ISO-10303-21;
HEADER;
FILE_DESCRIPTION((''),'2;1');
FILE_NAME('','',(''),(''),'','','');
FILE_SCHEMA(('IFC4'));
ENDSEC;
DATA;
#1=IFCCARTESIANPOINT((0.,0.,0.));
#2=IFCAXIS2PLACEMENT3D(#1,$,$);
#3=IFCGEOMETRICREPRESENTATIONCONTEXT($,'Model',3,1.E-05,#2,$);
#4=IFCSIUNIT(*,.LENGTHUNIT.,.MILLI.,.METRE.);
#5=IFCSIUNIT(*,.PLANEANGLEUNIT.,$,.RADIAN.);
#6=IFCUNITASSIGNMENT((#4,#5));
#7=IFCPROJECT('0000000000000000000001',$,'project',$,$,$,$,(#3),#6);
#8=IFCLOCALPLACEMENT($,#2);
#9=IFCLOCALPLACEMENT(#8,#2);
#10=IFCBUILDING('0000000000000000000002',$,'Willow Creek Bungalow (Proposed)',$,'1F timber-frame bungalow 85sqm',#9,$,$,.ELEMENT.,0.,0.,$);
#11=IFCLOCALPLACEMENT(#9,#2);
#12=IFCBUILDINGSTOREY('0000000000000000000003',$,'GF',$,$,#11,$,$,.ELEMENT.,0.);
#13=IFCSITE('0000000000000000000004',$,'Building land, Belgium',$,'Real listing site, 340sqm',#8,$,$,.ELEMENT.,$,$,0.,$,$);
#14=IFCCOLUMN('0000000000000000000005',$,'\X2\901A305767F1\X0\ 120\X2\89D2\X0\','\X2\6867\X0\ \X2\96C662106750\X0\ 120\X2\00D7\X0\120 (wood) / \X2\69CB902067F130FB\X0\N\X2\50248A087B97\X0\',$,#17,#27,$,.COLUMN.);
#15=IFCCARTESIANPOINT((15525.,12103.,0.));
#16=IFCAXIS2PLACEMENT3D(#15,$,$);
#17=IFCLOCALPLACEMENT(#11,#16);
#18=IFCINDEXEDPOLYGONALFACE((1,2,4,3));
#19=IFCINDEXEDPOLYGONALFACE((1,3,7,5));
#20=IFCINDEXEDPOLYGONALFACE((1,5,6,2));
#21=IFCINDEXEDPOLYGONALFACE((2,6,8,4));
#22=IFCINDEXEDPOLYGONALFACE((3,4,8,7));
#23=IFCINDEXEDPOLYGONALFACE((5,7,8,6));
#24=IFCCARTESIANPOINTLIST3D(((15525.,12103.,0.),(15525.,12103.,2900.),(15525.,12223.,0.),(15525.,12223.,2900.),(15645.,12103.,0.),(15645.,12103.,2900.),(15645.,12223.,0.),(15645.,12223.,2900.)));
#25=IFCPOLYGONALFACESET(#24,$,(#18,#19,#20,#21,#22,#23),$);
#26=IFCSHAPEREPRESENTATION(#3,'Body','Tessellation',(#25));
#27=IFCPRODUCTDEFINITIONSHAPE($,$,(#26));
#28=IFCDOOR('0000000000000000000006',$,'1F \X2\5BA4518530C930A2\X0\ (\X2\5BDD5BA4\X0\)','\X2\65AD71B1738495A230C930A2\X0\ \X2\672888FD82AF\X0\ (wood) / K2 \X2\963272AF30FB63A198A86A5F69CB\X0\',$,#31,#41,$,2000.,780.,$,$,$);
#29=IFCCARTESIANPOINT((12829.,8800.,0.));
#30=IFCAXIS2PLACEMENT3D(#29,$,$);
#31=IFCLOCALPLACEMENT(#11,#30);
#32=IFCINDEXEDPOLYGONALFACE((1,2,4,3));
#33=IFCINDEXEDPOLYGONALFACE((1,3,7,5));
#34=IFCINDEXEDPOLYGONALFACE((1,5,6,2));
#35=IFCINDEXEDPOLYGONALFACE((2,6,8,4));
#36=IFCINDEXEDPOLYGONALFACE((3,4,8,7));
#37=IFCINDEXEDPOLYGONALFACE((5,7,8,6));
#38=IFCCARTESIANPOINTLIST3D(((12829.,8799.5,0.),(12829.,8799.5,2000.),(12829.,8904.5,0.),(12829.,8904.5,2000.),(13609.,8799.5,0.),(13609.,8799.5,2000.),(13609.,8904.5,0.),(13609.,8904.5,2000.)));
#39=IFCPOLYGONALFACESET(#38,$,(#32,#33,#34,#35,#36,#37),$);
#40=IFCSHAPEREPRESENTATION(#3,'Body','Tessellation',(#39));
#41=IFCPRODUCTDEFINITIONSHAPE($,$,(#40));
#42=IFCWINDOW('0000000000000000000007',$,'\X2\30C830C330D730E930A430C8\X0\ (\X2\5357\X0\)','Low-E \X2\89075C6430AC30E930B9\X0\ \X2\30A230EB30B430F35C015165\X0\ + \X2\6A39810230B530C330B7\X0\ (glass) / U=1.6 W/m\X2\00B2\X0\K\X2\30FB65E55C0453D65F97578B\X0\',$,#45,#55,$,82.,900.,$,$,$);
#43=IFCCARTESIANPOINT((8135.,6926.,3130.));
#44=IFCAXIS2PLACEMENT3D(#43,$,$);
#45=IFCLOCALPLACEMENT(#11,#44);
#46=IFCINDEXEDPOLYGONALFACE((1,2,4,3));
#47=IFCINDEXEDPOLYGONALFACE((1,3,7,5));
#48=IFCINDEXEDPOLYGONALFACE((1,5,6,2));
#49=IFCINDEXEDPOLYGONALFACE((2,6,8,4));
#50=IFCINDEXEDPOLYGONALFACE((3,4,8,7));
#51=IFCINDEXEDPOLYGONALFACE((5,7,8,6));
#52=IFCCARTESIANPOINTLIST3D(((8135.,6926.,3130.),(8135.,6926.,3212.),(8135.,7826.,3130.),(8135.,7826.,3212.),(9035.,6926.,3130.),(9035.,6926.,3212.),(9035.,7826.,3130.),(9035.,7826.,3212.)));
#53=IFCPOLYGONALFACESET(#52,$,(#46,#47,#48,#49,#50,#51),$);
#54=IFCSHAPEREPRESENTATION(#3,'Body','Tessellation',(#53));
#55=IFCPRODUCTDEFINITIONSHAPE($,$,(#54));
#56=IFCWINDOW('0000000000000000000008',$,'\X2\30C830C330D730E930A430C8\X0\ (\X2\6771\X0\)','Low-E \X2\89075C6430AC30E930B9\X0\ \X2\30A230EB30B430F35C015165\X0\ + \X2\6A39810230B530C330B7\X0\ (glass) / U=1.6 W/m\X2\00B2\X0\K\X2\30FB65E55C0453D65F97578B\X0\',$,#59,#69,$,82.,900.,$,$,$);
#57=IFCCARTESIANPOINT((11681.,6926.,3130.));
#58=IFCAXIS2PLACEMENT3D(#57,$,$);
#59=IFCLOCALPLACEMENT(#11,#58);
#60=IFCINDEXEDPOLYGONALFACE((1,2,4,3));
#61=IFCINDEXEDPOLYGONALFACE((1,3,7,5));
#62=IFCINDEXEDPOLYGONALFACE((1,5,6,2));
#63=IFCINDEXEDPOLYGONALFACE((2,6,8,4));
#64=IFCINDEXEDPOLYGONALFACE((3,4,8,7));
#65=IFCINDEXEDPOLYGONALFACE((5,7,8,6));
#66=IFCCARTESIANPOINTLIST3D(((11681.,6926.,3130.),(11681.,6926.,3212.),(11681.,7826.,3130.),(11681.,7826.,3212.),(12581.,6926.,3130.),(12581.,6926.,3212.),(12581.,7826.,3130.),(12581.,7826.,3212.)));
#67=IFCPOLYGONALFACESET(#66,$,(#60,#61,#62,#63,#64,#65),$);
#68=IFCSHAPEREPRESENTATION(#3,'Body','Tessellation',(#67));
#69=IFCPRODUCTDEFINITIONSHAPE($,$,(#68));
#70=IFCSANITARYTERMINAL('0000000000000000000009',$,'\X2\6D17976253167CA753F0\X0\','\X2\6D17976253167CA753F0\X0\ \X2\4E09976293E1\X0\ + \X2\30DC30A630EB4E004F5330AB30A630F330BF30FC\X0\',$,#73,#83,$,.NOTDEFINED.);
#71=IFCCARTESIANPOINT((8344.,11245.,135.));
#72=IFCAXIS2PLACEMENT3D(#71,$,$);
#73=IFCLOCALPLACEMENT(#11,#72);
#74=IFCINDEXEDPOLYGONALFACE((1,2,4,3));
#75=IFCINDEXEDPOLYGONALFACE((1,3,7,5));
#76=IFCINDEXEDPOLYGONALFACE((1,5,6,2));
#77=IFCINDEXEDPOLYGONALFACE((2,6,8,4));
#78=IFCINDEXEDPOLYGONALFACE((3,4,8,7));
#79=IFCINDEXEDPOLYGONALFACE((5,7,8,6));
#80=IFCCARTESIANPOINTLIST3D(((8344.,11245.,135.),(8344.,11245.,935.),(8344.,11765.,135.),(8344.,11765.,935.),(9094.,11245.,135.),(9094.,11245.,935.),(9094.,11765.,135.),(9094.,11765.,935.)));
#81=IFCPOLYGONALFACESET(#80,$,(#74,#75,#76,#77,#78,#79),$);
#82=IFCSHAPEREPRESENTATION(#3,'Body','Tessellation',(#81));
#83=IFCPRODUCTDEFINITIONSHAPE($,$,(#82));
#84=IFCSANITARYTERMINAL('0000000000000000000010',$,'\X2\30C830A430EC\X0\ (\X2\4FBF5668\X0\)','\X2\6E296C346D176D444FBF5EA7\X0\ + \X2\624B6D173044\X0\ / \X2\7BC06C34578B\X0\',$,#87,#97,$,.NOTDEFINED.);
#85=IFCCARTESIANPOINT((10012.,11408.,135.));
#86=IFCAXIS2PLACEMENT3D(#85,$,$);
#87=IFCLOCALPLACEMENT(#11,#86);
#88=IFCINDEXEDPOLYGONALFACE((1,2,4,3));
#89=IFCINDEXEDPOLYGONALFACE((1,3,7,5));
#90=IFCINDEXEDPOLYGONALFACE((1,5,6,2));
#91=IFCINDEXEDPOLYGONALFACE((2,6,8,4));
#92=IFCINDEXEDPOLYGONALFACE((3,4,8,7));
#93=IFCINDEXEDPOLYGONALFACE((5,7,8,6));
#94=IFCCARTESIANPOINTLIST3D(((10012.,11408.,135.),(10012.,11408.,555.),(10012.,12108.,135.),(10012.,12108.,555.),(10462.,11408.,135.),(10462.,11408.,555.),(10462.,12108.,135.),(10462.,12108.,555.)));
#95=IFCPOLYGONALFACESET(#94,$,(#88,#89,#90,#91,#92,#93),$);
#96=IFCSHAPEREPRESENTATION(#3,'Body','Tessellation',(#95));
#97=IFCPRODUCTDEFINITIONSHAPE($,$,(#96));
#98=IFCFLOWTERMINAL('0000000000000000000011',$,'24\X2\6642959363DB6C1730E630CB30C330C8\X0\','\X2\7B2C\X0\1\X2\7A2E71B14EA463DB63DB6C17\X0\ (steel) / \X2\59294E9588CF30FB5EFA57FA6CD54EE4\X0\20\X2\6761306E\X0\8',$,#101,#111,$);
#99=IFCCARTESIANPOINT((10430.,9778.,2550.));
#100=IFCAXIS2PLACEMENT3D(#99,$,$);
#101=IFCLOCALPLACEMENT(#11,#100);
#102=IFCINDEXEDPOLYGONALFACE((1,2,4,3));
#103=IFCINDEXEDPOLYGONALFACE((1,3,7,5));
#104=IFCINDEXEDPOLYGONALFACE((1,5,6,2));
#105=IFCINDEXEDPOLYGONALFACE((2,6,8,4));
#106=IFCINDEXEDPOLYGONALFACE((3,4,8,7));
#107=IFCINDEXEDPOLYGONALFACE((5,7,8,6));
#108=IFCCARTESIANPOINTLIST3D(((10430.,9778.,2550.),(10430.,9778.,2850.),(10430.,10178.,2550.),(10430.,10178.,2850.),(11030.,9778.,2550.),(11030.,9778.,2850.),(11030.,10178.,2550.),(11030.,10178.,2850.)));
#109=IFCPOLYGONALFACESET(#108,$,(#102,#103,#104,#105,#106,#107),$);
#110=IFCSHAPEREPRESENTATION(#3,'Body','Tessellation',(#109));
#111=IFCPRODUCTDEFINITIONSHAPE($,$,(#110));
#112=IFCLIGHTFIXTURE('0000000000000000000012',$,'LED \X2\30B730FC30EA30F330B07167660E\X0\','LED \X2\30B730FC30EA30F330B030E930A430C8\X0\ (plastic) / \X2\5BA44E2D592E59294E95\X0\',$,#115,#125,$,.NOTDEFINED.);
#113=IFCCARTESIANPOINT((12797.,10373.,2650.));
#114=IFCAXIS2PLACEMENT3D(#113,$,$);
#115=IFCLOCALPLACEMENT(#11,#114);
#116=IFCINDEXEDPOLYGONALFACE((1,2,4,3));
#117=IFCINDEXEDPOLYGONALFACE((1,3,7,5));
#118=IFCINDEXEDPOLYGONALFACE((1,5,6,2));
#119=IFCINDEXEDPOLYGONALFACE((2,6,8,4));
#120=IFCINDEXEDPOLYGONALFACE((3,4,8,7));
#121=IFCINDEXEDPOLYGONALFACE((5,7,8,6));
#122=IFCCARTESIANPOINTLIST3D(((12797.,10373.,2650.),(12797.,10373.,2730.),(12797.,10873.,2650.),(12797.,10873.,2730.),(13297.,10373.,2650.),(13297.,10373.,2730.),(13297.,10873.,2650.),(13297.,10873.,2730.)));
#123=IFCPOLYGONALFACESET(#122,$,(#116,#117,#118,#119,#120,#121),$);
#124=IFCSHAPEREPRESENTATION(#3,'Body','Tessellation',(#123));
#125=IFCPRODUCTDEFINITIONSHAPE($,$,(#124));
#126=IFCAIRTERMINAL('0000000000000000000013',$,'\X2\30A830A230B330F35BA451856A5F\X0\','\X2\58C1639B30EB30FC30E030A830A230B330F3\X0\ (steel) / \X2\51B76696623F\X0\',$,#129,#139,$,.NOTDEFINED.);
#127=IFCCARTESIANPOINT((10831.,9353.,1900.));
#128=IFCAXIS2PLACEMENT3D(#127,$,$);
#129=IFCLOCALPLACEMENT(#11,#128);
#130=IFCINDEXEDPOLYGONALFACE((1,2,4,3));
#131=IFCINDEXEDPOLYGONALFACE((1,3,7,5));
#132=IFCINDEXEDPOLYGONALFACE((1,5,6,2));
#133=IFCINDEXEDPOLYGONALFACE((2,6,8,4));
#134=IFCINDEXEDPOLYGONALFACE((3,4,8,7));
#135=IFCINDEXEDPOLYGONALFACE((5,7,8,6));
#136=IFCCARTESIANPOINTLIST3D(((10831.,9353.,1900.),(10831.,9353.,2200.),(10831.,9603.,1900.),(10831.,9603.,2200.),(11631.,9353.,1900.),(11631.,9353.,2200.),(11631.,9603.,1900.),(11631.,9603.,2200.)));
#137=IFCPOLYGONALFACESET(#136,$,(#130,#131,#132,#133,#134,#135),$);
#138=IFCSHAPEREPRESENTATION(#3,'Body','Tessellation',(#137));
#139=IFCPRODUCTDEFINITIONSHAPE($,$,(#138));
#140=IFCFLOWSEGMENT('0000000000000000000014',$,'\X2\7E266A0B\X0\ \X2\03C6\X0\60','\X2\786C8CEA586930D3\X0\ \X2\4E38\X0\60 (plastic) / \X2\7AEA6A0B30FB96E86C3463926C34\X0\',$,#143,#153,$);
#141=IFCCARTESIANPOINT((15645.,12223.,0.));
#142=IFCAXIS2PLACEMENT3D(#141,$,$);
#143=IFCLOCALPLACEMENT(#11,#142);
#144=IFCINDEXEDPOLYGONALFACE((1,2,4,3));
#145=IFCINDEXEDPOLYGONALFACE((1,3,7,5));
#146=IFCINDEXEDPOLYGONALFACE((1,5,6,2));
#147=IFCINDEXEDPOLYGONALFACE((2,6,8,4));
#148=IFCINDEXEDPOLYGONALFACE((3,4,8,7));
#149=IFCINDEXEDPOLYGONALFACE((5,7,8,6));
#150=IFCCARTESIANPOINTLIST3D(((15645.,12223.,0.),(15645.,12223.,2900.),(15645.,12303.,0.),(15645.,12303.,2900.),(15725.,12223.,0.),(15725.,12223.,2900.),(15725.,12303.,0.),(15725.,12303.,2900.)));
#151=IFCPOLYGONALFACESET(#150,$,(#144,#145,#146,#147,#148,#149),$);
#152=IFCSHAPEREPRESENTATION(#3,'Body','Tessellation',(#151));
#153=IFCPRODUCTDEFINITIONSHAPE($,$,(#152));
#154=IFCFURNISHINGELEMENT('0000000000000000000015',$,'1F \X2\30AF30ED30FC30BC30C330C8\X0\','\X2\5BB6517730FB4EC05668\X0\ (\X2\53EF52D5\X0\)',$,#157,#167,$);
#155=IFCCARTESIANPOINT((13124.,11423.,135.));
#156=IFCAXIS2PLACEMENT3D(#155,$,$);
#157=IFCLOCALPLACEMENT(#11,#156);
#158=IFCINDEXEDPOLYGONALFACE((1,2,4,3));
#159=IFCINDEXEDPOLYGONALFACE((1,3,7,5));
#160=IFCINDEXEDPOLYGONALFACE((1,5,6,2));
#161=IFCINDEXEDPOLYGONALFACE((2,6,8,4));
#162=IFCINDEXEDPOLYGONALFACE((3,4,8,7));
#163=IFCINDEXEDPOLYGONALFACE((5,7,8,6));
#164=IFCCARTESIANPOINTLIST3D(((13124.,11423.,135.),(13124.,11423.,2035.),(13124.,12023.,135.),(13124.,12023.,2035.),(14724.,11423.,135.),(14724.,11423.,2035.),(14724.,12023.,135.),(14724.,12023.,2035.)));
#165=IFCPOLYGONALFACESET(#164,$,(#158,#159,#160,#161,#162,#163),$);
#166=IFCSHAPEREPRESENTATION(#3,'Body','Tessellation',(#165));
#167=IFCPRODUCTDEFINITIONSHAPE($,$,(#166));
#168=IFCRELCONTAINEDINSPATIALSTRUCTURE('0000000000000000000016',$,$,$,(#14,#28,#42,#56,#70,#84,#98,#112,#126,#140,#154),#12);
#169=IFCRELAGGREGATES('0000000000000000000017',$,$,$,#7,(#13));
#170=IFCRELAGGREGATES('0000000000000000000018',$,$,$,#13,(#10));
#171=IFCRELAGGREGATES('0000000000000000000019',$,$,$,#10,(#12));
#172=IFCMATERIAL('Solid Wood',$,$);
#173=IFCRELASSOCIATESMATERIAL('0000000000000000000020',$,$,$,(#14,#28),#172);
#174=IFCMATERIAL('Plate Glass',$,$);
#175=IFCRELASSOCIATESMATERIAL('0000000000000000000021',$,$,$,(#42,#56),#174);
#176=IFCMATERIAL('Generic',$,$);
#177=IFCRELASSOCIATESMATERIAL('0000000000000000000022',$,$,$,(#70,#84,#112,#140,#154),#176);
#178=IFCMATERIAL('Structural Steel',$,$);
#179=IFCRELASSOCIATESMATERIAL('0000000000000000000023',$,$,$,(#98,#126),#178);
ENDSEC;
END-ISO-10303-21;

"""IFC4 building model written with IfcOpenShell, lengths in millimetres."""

from ifc_helpers import new_model, si_unit, frame, frame_2d, origin, place, context, project, spatial, rectangle, extrude, material, element, save


model = new_model("IFC4")

# Units and contexts
model_context = context("Model", 3, precision=1e-05, world=origin())
ifc_project = project(units=[si_unit("LENGTHUNIT", "METRE", prefix="MILLI"), si_unit("PLANEANGLEUNIT", "RADIAN")], contexts=[model_context])

# Site, building, storey
site_placement = place(None, origin())
site = spatial("IfcSite", under=ifc_project, at=site_placement, Name="Building land, Belgium", ObjectType="Real listing site, 340sqm", CompositionType="ELEMENT", RefElevation=0.0)
building_placement = place(site_placement, origin())
building = spatial("IfcBuilding", under=site, at=building_placement, Name="Willow Creek Bungalow (Proposed)", ObjectType="1F timber-frame bungalow 85sqm", CompositionType="ELEMENT", ElevationOfRefHeight=0.0, ElevationOfTerrain=0.0)
storey_placement = place(building_placement, origin())
storey = spatial("IfcBuildingStorey", under=building, at=storey_placement, Name="GF", CompositionType="ELEMENT", Elevation=0.0)

# Column
ifc_material_1 = material(Name="Solid Wood")
column_1_placement = place(storey_placement, frame((15525.0, 12103.0, 0.0)))
element("IfcColumn", 1, at=column_1_placement, inside=storey, material=ifc_material_1, Name="通し柱 120角", Description="桧 集成材 120×120 (wood) / 構造柱・N値計算", PredefinedType="COLUMN", context=model_context, shape_type="SweptSolid", body=[
    extrude(rectangle(XDim=120.0, YDim=120.0, at=frame_2d((60.0, 60.0))), frame((15525.0, 12103.0, 0.0)), (0.0, 0.0, 1.0), 2900.0),
])

# Door
door_placement = place(storey_placement, frame((12829.0, 8800.0, 0.0)))
element("IfcDoor", 2, at=door_placement, inside=storey, material=ifc_material_1, Name="1F 室内ドア (寝室)", Description="断熱玄関ドア 木製芯 (wood) / K2 防犯・採風機構", OverallHeight=2000.0, OverallWidth=780.0, context=model_context, shape_type="SweptSolid", body=[
    extrude(rectangle(XDim=780.0, YDim=105.0, at=frame_2d((390.0, 52.0))), frame((12829.0, 8800.0, 0.0)), (0.0, 0.0, 1.0), 2000.0),
])

# Windows
ifc_material_2 = material(Name="Plate Glass")
window_1_placement = place(storey_placement, frame((8135.0, 6926.0, 3130.0)))
element("IfcWindow", 3, at=window_1_placement, inside=storey, material=ifc_material_2, Name="トップライト (南)", Description="Low-E 複層ガラス アルゴン封入 + 樹脂サッシ (glass) / U=1.6 W/m²K・日射取得型", OverallHeight=82.0, OverallWidth=900.0, context=model_context, shape_type="SweptSolid", body=[
    extrude(rectangle(XDim=900.0, YDim=900.0, at=frame_2d((450.0, 450.0))), frame((8135.0, 6926.0, 3130.0)), (0.0, 0.0, 1.0), 82.0),
])
window_2_placement = place(storey_placement, frame((11681.0, 6926.0, 3130.0)))
element("IfcWindow", 4, at=window_2_placement, inside=storey, material=ifc_material_2, Name="トップライト (東)", Description="Low-E 複層ガラス アルゴン封入 + 樹脂サッシ (glass) / U=1.6 W/m²K・日射取得型", OverallHeight=82.0, OverallWidth=900.0, context=model_context, shape_type="SweptSolid", body=[
    extrude(rectangle(XDim=900.0, YDim=900.0, at=frame_2d((450.0, 450.0))), frame((11681.0, 6926.0, 3130.0)), (0.0, 0.0, 1.0), 82.0),
])

# Sanitary terminals
ifc_material_3 = material(Name="Generic")
sanitary_terminal_1_placement = place(storey_placement, frame((8344.0, 11245.0, 135.0)))
element("IfcSanitaryTerminal", 5, at=sanitary_terminal_1_placement, inside=storey, material=ifc_material_3, Name="洗面化粧台", Description="洗面化粧台 三面鏡 + ボウル一体カウンター", PredefinedType="NOTDEFINED", context=model_context, shape_type="SweptSolid", body=[
    extrude(rectangle(XDim=750.0, YDim=520.0, at=frame_2d((375.0, 260.0))), frame((8344.0, 11245.0, 135.0)), (0.0, 0.0, 1.0), 800.0),
])
sanitary_terminal_2_placement = place(storey_placement, frame((10012.0, 11408.0, 135.0)))
element("IfcSanitaryTerminal", 6, at=sanitary_terminal_2_placement, inside=storey, material=ifc_material_3, Name="トイレ (便器)", Description="温水洗浄便座 + 手洗い / 節水型", PredefinedType="NOTDEFINED", context=model_context, shape_type="SweptSolid", body=[
    extrude(rectangle(XDim=450.0, YDim=700.0, at=frame_2d((225.0, 350.0))), frame((10012.0, 11408.0, 135.0)), (0.0, 0.0, 1.0), 420.0),
])

# Flow terminal
ifc_material_4 = material(Name="Structural Steel")
flow_terminal_placement = place(storey_placement, frame((10430.0, 9778.0, 2550.0)))
element("IfcFlowTerminal", 7, at=flow_terminal_placement, inside=storey, material=ifc_material_4, Name="24時間換気ユニット", Description="第1種熱交換換気 (steel) / 天井裏・建基法令20条の8", context=model_context, shape_type="SweptSolid", body=[
    extrude(rectangle(XDim=600.0, YDim=400.0, at=frame_2d((300.0, 200.0))), frame((10430.0, 9778.0, 2550.0)), (0.0, 0.0, 1.0), 300.0),
])

# Light fixture
light_fixture_placement = place(storey_placement, frame((12797.0, 10373.0, 2650.0)))
element("IfcLightFixture", 8, at=light_fixture_placement, inside=storey, material=ifc_material_3, Name="LED シーリング照明", Description="LED シーリングライト (plastic) / 室中央天井", PredefinedType="NOTDEFINED", context=model_context, shape_type="SweptSolid", body=[
    extrude(rectangle(XDim=500.0, YDim=500.0, at=frame_2d((250.0, 250.0))), frame((12797.0, 10373.0, 2650.0)), (0.0, 0.0, 1.0), 80.0),
])

# Air terminal
air_terminal_placement = place(storey_placement, frame((10831.0, 9353.0, 1900.0)))
element("IfcAirTerminal", 9, at=air_terminal_placement, inside=storey, material=ifc_material_4, Name="エアコン室内機", Description="壁掛ルームエアコン (steel) / 冷暖房", PredefinedType="NOTDEFINED", context=model_context, shape_type="SweptSolid", body=[
    extrude(rectangle(XDim=800.0, YDim=250.0, at=frame_2d((400.0, 125.0))), frame((10831.0, 9353.0, 1900.0)), (0.0, 0.0, 1.0), 300.0),
])

# Flow segment
flow_segment_placement = place(storey_placement, frame((15645.0, 12223.0, 0.0)))
element("IfcFlowSegment", 10, at=flow_segment_placement, inside=storey, material=ifc_material_3, Name="縦樋 φ60", Description="硬質塩ビ 丸60 (plastic) / 竪樋・雨水排水", context=model_context, shape_type="SweptSolid", body=[
    extrude(rectangle(XDim=80.0, YDim=80.0, at=frame_2d((40.0, 40.0))), frame((15645.0, 12223.0, 0.0)), (0.0, 0.0, 1.0), 2900.0),
])

# Furnishing element
furnishing_placement = place(storey_placement, frame((13124.0, 11423.0, 135.0)))
element("IfcFurnishingElement", 11, at=furnishing_placement, inside=storey, material=ifc_material_3, Name="1F クローゼット", Description="家具・什器 (可動)", context=model_context, shape_type="SweptSolid", body=[
    extrude(rectangle(XDim=1600.0, YDim=600.0, at=frame_2d((800.0, 300.0))), frame((13124.0, 11423.0, 135.0)), (0.0, 0.0, 1.0), 1900.0),
])

save(model, "model.ifc")
